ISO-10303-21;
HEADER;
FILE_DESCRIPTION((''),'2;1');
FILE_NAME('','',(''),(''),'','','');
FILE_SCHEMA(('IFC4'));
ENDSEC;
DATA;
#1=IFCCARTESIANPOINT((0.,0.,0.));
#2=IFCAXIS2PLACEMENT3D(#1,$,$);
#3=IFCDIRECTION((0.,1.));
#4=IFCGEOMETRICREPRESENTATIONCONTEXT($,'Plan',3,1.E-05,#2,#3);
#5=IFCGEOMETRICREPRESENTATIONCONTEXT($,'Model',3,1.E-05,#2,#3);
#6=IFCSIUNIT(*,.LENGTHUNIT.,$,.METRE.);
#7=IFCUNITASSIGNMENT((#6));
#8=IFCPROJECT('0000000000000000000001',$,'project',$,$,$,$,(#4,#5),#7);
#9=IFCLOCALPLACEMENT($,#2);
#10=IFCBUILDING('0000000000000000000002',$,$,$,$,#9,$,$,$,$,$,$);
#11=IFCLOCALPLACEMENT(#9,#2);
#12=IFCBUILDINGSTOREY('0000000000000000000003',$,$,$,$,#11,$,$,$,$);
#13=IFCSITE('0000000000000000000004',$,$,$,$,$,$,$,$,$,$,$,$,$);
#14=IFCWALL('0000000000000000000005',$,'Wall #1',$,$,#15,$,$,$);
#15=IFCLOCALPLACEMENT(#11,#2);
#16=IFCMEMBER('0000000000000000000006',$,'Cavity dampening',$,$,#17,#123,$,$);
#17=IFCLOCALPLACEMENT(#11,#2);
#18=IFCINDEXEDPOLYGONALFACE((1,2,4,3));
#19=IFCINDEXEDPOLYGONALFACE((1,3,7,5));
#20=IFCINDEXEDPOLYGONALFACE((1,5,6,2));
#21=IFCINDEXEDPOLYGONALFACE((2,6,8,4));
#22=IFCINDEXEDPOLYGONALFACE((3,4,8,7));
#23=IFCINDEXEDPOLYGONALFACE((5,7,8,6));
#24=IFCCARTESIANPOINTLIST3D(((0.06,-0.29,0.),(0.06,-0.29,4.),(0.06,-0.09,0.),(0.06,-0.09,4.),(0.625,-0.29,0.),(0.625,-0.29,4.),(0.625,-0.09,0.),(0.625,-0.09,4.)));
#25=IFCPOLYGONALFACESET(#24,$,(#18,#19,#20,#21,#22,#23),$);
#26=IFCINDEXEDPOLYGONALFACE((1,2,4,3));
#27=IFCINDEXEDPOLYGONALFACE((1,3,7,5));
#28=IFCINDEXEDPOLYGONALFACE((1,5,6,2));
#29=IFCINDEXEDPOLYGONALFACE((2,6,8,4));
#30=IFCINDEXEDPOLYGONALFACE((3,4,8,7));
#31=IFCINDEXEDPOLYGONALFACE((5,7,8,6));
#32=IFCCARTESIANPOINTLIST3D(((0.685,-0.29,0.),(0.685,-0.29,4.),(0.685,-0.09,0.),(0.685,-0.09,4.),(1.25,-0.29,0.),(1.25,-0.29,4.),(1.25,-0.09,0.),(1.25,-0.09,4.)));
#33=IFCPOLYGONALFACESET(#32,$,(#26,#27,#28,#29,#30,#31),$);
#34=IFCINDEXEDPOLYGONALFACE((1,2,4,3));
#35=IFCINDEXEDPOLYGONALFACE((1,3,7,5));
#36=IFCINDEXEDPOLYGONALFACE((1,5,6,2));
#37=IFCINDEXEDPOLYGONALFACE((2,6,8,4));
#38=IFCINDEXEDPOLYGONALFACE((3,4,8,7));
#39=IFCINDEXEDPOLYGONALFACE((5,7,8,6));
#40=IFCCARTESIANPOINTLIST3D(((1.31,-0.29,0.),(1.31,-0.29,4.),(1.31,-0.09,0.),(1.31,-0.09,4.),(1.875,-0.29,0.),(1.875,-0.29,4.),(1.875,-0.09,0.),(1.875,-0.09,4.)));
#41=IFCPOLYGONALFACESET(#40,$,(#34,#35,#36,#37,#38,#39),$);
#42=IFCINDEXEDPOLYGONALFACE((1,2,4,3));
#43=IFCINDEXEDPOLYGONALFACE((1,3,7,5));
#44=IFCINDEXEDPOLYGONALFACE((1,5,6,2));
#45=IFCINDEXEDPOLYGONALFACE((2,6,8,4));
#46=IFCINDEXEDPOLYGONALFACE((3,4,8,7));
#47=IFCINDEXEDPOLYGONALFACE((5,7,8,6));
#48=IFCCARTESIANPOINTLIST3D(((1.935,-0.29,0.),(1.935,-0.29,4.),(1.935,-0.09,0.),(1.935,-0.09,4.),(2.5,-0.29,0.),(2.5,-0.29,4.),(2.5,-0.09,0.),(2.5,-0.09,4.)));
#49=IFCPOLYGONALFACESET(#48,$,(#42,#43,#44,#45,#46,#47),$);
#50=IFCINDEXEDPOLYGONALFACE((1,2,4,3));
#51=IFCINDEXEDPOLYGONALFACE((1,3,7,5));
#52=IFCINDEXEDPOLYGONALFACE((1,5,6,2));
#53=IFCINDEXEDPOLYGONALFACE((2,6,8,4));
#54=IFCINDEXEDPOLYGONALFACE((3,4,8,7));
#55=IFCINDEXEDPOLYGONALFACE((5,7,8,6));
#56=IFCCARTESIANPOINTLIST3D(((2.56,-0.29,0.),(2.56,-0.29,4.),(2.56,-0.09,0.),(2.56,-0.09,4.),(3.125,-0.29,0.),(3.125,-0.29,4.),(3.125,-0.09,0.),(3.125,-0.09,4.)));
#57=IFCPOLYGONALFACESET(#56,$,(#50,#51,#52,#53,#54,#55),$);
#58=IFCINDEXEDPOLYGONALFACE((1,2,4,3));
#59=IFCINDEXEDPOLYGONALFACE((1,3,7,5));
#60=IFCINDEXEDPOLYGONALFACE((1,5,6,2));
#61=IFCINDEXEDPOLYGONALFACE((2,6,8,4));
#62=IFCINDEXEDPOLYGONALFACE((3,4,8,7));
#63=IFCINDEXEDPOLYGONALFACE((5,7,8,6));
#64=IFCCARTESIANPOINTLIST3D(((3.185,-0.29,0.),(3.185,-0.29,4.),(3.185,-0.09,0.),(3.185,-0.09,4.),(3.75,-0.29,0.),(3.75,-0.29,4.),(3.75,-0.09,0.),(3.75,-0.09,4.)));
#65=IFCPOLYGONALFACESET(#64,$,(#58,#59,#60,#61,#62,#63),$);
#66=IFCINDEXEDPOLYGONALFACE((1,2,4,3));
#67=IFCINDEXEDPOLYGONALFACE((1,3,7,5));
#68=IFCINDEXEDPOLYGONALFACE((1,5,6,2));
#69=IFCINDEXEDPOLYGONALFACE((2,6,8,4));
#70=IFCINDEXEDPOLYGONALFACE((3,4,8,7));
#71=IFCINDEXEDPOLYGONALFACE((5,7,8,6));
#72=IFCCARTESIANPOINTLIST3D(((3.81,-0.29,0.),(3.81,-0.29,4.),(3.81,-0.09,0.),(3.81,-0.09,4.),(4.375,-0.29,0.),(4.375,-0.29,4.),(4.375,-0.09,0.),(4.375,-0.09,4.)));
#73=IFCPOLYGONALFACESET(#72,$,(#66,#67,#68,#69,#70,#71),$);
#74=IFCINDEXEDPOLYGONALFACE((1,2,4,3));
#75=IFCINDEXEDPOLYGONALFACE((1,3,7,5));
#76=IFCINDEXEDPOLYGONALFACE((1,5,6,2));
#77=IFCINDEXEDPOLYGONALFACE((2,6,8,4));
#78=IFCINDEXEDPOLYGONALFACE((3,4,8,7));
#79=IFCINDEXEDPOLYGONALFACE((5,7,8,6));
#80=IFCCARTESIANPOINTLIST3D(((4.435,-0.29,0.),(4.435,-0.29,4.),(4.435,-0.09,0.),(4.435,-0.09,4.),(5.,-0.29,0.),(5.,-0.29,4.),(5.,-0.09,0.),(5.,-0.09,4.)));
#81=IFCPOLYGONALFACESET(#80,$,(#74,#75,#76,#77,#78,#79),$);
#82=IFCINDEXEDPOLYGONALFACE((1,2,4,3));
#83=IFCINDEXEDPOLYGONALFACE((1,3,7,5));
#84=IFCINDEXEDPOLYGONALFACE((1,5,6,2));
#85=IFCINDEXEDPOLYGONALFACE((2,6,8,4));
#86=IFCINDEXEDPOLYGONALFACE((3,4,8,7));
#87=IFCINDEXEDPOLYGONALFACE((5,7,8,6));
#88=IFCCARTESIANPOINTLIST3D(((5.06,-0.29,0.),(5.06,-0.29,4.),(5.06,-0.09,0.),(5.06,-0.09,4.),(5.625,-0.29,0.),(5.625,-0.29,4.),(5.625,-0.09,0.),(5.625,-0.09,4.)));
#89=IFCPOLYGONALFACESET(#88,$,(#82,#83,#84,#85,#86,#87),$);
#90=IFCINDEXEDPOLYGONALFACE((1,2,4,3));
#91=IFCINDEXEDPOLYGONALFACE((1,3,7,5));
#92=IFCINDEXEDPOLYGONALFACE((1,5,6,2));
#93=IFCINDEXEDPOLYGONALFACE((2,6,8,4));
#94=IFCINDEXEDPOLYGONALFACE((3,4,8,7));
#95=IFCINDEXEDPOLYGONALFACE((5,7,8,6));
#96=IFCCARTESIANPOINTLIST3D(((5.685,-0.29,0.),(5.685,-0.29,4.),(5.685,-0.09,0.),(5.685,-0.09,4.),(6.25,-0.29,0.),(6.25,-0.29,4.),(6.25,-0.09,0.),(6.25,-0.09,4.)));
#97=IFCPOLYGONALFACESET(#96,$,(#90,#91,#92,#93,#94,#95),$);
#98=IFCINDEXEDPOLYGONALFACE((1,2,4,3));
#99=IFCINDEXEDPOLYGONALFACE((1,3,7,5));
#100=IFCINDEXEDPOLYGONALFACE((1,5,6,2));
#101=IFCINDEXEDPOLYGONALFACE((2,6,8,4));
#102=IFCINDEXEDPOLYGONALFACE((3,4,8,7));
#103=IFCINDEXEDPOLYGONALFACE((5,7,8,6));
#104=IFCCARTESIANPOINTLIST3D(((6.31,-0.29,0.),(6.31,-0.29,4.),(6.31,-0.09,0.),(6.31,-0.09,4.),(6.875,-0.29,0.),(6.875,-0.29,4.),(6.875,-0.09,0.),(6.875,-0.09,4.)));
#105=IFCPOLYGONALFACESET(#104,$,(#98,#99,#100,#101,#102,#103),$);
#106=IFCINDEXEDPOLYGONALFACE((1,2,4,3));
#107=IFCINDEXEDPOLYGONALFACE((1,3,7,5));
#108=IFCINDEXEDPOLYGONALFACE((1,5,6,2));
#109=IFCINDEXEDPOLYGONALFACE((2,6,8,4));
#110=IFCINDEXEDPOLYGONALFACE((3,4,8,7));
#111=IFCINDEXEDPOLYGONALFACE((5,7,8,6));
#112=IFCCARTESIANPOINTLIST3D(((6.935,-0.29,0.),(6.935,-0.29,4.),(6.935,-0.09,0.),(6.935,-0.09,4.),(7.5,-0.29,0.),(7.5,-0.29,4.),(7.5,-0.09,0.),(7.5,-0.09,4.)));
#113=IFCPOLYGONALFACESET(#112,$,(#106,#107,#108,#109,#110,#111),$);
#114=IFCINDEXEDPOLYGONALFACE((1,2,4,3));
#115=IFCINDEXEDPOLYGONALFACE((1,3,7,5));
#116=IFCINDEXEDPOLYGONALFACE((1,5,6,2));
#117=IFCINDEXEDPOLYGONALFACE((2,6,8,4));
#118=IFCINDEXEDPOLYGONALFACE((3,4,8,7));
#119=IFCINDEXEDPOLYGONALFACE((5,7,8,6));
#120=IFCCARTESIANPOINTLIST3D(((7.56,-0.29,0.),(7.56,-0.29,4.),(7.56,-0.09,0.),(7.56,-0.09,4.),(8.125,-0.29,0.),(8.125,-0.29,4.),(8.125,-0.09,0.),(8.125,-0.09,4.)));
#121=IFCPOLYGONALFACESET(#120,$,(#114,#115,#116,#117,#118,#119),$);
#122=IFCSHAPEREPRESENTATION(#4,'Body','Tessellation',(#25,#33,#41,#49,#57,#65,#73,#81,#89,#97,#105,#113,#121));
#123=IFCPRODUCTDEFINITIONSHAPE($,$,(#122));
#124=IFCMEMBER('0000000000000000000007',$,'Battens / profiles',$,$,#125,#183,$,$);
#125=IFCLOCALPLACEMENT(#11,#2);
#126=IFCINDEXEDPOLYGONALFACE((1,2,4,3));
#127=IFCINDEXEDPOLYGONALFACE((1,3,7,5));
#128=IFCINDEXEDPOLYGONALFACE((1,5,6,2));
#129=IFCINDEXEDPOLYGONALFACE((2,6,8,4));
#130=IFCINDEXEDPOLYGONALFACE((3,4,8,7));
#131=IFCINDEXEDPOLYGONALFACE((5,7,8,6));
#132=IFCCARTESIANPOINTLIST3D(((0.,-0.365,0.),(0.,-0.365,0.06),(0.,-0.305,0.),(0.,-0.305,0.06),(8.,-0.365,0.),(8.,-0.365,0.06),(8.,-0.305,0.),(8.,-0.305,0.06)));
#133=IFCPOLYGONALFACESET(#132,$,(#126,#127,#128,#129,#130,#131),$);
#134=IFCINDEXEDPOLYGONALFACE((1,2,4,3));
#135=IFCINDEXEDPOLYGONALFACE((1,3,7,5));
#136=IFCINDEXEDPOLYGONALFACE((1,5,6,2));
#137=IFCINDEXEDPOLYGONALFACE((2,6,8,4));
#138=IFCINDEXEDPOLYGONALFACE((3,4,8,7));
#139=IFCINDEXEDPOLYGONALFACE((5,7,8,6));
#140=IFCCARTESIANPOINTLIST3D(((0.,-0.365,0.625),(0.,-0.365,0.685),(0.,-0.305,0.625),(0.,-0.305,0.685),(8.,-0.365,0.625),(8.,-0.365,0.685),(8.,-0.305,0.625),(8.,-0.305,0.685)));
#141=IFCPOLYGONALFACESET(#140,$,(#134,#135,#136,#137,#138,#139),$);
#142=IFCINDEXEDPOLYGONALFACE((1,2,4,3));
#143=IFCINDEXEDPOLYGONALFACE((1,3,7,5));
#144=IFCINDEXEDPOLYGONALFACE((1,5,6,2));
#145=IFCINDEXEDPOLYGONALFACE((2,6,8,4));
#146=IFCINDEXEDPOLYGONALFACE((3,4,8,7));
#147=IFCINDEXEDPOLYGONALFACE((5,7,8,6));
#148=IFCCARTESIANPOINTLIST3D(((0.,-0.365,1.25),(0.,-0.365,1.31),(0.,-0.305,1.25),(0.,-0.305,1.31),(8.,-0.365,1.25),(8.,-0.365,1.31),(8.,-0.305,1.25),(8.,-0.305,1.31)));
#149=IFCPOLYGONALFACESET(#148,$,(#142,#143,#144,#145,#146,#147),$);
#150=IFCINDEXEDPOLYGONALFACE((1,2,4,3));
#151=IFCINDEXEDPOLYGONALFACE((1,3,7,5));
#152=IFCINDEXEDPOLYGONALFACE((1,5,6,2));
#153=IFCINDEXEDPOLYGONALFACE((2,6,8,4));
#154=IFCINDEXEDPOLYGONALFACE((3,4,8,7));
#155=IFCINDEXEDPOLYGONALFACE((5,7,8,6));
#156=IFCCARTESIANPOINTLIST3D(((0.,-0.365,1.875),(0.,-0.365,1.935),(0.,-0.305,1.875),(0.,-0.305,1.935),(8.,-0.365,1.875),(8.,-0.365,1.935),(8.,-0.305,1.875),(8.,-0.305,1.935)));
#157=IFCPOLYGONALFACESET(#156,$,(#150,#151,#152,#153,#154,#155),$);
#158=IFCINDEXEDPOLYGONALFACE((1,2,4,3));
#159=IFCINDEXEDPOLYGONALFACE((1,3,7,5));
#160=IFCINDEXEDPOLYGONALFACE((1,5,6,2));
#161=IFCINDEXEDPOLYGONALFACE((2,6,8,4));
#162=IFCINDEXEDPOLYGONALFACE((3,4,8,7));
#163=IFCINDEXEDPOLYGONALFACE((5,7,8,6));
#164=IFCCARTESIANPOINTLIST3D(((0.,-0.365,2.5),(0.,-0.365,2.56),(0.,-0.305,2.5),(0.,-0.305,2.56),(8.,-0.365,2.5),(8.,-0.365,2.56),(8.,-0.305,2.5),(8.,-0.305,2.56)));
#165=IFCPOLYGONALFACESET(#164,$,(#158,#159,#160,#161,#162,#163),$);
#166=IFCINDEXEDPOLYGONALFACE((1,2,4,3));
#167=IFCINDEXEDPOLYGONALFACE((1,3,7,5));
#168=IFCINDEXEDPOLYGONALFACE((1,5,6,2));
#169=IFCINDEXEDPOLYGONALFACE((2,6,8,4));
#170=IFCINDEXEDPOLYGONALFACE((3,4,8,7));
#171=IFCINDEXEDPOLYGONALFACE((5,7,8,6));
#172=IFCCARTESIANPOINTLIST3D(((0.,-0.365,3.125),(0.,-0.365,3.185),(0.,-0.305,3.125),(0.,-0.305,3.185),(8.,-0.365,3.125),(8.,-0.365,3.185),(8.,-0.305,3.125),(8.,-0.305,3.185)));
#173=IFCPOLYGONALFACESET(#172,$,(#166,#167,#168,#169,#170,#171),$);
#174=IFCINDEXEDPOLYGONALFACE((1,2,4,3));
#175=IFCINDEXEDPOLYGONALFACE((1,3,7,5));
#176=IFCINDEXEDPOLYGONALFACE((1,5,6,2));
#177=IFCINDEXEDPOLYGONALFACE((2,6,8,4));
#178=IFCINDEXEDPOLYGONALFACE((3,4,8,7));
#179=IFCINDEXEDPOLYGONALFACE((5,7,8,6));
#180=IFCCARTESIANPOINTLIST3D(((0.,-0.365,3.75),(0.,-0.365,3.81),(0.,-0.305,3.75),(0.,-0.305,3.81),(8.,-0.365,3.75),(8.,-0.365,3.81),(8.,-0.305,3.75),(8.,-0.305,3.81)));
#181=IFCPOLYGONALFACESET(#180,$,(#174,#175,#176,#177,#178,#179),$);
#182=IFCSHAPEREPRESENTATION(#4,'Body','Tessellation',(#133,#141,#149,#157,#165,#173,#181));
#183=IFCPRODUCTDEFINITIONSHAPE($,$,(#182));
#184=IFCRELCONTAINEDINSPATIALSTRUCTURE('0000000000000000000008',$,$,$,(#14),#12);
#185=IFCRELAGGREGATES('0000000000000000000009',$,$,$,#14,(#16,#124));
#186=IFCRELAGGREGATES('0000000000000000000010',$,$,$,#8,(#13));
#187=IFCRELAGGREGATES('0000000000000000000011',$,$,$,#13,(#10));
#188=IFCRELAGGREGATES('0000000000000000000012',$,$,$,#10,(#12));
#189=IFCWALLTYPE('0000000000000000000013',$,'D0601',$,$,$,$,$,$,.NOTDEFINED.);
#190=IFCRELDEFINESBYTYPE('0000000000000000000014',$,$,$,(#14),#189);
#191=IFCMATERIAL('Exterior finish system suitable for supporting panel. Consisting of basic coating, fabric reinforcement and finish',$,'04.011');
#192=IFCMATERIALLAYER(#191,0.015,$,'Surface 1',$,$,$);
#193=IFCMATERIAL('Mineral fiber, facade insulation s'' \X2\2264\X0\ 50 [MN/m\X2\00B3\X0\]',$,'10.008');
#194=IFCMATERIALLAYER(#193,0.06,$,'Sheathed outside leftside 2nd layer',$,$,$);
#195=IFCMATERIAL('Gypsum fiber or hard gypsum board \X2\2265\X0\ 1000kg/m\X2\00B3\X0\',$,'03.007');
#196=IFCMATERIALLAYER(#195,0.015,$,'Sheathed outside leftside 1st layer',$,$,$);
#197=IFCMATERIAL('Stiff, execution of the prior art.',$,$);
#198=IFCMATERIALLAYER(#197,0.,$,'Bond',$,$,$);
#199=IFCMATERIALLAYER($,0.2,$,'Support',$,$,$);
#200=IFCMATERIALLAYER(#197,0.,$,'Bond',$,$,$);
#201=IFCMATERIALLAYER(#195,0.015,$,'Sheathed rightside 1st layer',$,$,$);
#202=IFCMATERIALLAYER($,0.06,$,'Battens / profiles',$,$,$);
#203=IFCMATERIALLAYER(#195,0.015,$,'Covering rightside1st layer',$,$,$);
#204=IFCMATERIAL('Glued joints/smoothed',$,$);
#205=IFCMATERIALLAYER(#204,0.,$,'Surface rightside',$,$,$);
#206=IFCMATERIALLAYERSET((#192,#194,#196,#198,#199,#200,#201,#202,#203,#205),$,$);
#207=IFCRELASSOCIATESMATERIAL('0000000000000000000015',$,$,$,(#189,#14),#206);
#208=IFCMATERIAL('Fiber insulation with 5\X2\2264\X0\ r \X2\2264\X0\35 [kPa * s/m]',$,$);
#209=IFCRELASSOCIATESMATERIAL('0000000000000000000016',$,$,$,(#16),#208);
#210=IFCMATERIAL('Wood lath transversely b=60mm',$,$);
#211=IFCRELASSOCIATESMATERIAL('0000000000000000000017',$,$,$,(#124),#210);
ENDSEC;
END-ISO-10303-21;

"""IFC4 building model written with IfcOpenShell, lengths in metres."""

from ifc_helpers import new_model, si_unit, direction, frame, frame_2d, origin, place, context, project, spatial, rectangle, extrude, material, layer, layer_set, type_object, element, aggregate, save


model = new_model("IFC4")

# Units and contexts
plan_context = context("Plan", 3, precision=1e-05, world=origin(), true_north=direction((0.0, 1.0)))
model_context = context("Model", 3, precision=1e-05, world=origin(), true_north=direction((0.0, 1.0)))
ifc_project = project(units=[si_unit("LENGTHUNIT", "METRE")], contexts=[plan_context, model_context])

# Site, building, storey
site = spatial("IfcSite", under=ifc_project)
building_placement = place(None, origin())
building = spatial("IfcBuilding", under=site, at=building_placement)
storey_placement = place(building_placement, origin())
storey = spatial("IfcBuildingStorey", under=building, at=storey_placement)

# Wall, members
ifc_material_1 = material(Name="Exterior finish system suitable for supporting panel. Consisting of basic coating, fabric reinforcement and finish", Category="04.011")
ifc_layer_1 = layer(ifc_material_1, 0.015, Name="Surface 1")
ifc_material_2 = material(Name="Mineral fiber, facade insulation s' ≤ 50 [MN/m³]", Category="10.008")
ifc_layer_2 = layer(ifc_material_2, 0.06, Name="Sheathed outside leftside 2nd layer")
ifc_material_3 = material(Name="Gypsum fiber or hard gypsum board ≥ 1000kg/m³", Category="03.007")
ifc_layer_3 = layer(ifc_material_3, 0.015, Name="Sheathed outside leftside 1st layer")
ifc_material_4 = material(Name="Stiff, execution of the prior art.")
ifc_layer_4 = layer(ifc_material_4, 0.0, Name="Bond")
ifc_layer_5 = layer(None, 0.2, Name="Support")
ifc_layer_6 = layer(ifc_material_4, 0.0, Name="Bond")
ifc_layer_7 = layer(ifc_material_3, 0.015, Name="Sheathed rightside 1st layer")
ifc_layer_8 = layer(None, 0.06, Name="Battens / profiles")
ifc_layer_9 = layer(ifc_material_3, 0.015, Name="Covering rightside1st layer")
ifc_material_5 = material(Name="Glued joints/smoothed")
ifc_layer_10 = layer(ifc_material_5, 0.0, Name="Surface rightside")
ifc_layer_set = layer_set([ifc_layer_1, ifc_layer_2, ifc_layer_3, ifc_layer_4, ifc_layer_5, ifc_layer_6, ifc_layer_7, ifc_layer_8, ifc_layer_9, ifc_layer_10])
wall_type = type_object("IfcWallType", Name="D0601", PredefinedType="NOTDEFINED", material=ifc_layer_set)
wall_placement = place(None, frame((0.0, 0.0, 0.0), z_axis=(0.0, -1.0, 0.0), x_axis=(1.0, 0.0, 0.0)))
wall = element("IfcWall", 1, at=wall_placement, inside=storey, type_object=wall_type, material=ifc_layer_set, Name="Wall #1")
ifc_material_6 = material(Name="Fiber insulation with 5≤ r ≤35 [kPa * s/m]")
member_1_placement = place(wall_placement, origin())
member_1 = element("IfcMember", 2, at=member_1_placement, material=ifc_material_6, Name="Cavity dampening", context=plan_context, shape_type="SweptSolid", body=[
    extrude(rectangle(XDim=0.565, YDim=0.2, at=frame_2d((0.2825, 0.1), x_axis=(1.0, 0.0))), frame((0.06, 4.0, 0.09), z_axis=(0.0, -1.0, 0.0), x_axis=(1.0, 0.0, 0.0)), (0.0, 0.0, 1.0), 4.0),
    extrude(rectangle(XDim=0.565, YDim=0.2, at=frame_2d((0.2825, 0.1), x_axis=(1.0, 0.0))), frame((0.685, 4.0, 0.09), z_axis=(0.0, -1.0, 0.0), x_axis=(1.0, 0.0, 0.0)), (0.0, 0.0, 1.0), 4.0),
    extrude(rectangle(XDim=0.565, YDim=0.2, at=frame_2d((0.2825, 0.1), x_axis=(1.0, 0.0))), frame((1.31, 4.0, 0.09), z_axis=(0.0, -1.0, 0.0), x_axis=(1.0, 0.0, 0.0)), (0.0, 0.0, 1.0), 4.0),
    extrude(rectangle(XDim=0.565, YDim=0.2, at=frame_2d((0.2825, 0.1), x_axis=(1.0, 0.0))), frame((1.935, 4.0, 0.09), z_axis=(0.0, -1.0, 0.0), x_axis=(1.0, 0.0, 0.0)), (0.0, 0.0, 1.0), 4.0),
    extrude(rectangle(XDim=0.565, YDim=0.2, at=frame_2d((0.2825, 0.1), x_axis=(1.0, 0.0))), frame((2.56, 4.0, 0.09), z_axis=(0.0, -1.0, 0.0), x_axis=(1.0, 0.0, 0.0)), (0.0, 0.0, 1.0), 4.0),
    extrude(rectangle(XDim=0.565, YDim=0.2, at=frame_2d((0.2825, 0.1), x_axis=(1.0, 0.0))), frame((3.185, 4.0, 0.09), z_axis=(0.0, -1.0, 0.0), x_axis=(1.0, 0.0, 0.0)), (0.0, 0.0, 1.0), 4.0),
    extrude(rectangle(XDim=0.565, YDim=0.2, at=frame_2d((0.2825, 0.1), x_axis=(1.0, 0.0))), frame((3.81, 4.0, 0.09), z_axis=(0.0, -1.0, 0.0), x_axis=(1.0, 0.0, 0.0)), (0.0, 0.0, 1.0), 4.0),
    extrude(rectangle(XDim=0.565, YDim=0.2, at=frame_2d((0.2825, 0.1), x_axis=(1.0, 0.0))), frame((4.435, 4.0, 0.09), z_axis=(0.0, -1.0, 0.0), x_axis=(1.0, 0.0, 0.0)), (0.0, 0.0, 1.0), 4.0),
    extrude(rectangle(XDim=0.565, YDim=0.2, at=frame_2d((0.2825, 0.1), x_axis=(1.0, 0.0))), frame((5.06, 4.0, 0.09), z_axis=(0.0, -1.0, 0.0), x_axis=(1.0, 0.0, 0.0)), (0.0, 0.0, 1.0), 4.0),
    extrude(rectangle(XDim=0.565, YDim=0.2, at=frame_2d((0.2825, 0.1), x_axis=(1.0, 0.0))), frame((5.685, 4.0, 0.09), z_axis=(0.0, -1.0, 0.0), x_axis=(1.0, 0.0, 0.0)), (0.0, 0.0, 1.0), 4.0),
    extrude(rectangle(XDim=0.565, YDim=0.2, at=frame_2d((0.2825, 0.1), x_axis=(1.0, 0.0))), frame((6.31, 4.0, 0.09), z_axis=(0.0, -1.0, 0.0), x_axis=(1.0, 0.0, 0.0)), (0.0, 0.0, 1.0), 4.0),
    extrude(rectangle(XDim=0.565, YDim=0.2, at=frame_2d((0.2825, 0.1), x_axis=(1.0, 0.0))), frame((6.935, 4.0, 0.09), z_axis=(0.0, -1.0, 0.0), x_axis=(1.0, 0.0, 0.0)), (0.0, 0.0, 1.0), 4.0),
    extrude(rectangle(XDim=0.565, YDim=0.2, at=frame_2d((0.2825, 0.1), x_axis=(1.0, 0.0))), frame((7.56, 4.0, 0.09), z_axis=(0.0, -1.0, 0.0), x_axis=(1.0, 0.0, 0.0)), (0.0, 0.0, 1.0), 4.0),
])
ifc_material_7 = material(Name="Wood lath transversely b=60mm")
member_2_placement = place(wall_placement, origin())
member_2 = element("IfcMember", 3, at=member_2_placement, material=ifc_material_7, Name="Battens / profiles", context=plan_context, shape_type="SweptSolid", body=[
    extrude(rectangle(XDim=0.06, YDim=0.06, at=frame_2d((0.03, 0.03), x_axis=(1.0, 0.0))), frame((0.0, 0.0, 0.305), z_axis=(1.0, 0.0, 0.0), x_axis=(0.0, 1.0, 0.0)), (0.0, 0.0, 1.0), 8.0),
    extrude(rectangle(XDim=0.06, YDim=0.06, at=frame_2d((0.03, 0.03), x_axis=(1.0, 0.0))), frame((0.0, 0.625, 0.305), z_axis=(1.0, 0.0, 0.0), x_axis=(0.0, 1.0, 0.0)), (0.0, 0.0, 1.0), 8.0),
    extrude(rectangle(XDim=0.06, YDim=0.06, at=frame_2d((0.03, 0.03), x_axis=(1.0, 0.0))), frame((0.0, 1.25, 0.305), z_axis=(1.0, 0.0, 0.0), x_axis=(0.0, 1.0, 0.0)), (0.0, 0.0, 1.0), 8.0),
    extrude(rectangle(XDim=0.06, YDim=0.06, at=frame_2d((0.03, 0.03), x_axis=(1.0, 0.0))), frame((0.0, 1.875, 0.305), z_axis=(1.0, 0.0, 0.0), x_axis=(0.0, 1.0, 0.0)), (0.0, 0.0, 1.0), 8.0),
    extrude(rectangle(XDim=0.06, YDim=0.06, at=frame_2d((0.03, 0.03), x_axis=(1.0, 0.0))), frame((0.0, 2.5, 0.305), z_axis=(1.0, 0.0, 0.0), x_axis=(0.0, 1.0, 0.0)), (0.0, 0.0, 1.0), 8.0),
    extrude(rectangle(XDim=0.06, YDim=0.06, at=frame_2d((0.03, 0.03), x_axis=(1.0, 0.0))), frame((0.0, 3.125, 0.305), z_axis=(1.0, 0.0, 0.0), x_axis=(0.0, 1.0, 0.0)), (0.0, 0.0, 1.0), 8.0),
    extrude(rectangle(XDim=0.06, YDim=0.06, at=frame_2d((0.03, 0.03), x_axis=(1.0, 0.0))), frame((0.0, 3.75, 0.305), z_axis=(1.0, 0.0, 0.0), x_axis=(0.0, 1.0, 0.0)), (0.0, 0.0, 1.0), 8.0),
])
aggregate(wall, [member_1, member_2])

save(model, "model.ifc")
